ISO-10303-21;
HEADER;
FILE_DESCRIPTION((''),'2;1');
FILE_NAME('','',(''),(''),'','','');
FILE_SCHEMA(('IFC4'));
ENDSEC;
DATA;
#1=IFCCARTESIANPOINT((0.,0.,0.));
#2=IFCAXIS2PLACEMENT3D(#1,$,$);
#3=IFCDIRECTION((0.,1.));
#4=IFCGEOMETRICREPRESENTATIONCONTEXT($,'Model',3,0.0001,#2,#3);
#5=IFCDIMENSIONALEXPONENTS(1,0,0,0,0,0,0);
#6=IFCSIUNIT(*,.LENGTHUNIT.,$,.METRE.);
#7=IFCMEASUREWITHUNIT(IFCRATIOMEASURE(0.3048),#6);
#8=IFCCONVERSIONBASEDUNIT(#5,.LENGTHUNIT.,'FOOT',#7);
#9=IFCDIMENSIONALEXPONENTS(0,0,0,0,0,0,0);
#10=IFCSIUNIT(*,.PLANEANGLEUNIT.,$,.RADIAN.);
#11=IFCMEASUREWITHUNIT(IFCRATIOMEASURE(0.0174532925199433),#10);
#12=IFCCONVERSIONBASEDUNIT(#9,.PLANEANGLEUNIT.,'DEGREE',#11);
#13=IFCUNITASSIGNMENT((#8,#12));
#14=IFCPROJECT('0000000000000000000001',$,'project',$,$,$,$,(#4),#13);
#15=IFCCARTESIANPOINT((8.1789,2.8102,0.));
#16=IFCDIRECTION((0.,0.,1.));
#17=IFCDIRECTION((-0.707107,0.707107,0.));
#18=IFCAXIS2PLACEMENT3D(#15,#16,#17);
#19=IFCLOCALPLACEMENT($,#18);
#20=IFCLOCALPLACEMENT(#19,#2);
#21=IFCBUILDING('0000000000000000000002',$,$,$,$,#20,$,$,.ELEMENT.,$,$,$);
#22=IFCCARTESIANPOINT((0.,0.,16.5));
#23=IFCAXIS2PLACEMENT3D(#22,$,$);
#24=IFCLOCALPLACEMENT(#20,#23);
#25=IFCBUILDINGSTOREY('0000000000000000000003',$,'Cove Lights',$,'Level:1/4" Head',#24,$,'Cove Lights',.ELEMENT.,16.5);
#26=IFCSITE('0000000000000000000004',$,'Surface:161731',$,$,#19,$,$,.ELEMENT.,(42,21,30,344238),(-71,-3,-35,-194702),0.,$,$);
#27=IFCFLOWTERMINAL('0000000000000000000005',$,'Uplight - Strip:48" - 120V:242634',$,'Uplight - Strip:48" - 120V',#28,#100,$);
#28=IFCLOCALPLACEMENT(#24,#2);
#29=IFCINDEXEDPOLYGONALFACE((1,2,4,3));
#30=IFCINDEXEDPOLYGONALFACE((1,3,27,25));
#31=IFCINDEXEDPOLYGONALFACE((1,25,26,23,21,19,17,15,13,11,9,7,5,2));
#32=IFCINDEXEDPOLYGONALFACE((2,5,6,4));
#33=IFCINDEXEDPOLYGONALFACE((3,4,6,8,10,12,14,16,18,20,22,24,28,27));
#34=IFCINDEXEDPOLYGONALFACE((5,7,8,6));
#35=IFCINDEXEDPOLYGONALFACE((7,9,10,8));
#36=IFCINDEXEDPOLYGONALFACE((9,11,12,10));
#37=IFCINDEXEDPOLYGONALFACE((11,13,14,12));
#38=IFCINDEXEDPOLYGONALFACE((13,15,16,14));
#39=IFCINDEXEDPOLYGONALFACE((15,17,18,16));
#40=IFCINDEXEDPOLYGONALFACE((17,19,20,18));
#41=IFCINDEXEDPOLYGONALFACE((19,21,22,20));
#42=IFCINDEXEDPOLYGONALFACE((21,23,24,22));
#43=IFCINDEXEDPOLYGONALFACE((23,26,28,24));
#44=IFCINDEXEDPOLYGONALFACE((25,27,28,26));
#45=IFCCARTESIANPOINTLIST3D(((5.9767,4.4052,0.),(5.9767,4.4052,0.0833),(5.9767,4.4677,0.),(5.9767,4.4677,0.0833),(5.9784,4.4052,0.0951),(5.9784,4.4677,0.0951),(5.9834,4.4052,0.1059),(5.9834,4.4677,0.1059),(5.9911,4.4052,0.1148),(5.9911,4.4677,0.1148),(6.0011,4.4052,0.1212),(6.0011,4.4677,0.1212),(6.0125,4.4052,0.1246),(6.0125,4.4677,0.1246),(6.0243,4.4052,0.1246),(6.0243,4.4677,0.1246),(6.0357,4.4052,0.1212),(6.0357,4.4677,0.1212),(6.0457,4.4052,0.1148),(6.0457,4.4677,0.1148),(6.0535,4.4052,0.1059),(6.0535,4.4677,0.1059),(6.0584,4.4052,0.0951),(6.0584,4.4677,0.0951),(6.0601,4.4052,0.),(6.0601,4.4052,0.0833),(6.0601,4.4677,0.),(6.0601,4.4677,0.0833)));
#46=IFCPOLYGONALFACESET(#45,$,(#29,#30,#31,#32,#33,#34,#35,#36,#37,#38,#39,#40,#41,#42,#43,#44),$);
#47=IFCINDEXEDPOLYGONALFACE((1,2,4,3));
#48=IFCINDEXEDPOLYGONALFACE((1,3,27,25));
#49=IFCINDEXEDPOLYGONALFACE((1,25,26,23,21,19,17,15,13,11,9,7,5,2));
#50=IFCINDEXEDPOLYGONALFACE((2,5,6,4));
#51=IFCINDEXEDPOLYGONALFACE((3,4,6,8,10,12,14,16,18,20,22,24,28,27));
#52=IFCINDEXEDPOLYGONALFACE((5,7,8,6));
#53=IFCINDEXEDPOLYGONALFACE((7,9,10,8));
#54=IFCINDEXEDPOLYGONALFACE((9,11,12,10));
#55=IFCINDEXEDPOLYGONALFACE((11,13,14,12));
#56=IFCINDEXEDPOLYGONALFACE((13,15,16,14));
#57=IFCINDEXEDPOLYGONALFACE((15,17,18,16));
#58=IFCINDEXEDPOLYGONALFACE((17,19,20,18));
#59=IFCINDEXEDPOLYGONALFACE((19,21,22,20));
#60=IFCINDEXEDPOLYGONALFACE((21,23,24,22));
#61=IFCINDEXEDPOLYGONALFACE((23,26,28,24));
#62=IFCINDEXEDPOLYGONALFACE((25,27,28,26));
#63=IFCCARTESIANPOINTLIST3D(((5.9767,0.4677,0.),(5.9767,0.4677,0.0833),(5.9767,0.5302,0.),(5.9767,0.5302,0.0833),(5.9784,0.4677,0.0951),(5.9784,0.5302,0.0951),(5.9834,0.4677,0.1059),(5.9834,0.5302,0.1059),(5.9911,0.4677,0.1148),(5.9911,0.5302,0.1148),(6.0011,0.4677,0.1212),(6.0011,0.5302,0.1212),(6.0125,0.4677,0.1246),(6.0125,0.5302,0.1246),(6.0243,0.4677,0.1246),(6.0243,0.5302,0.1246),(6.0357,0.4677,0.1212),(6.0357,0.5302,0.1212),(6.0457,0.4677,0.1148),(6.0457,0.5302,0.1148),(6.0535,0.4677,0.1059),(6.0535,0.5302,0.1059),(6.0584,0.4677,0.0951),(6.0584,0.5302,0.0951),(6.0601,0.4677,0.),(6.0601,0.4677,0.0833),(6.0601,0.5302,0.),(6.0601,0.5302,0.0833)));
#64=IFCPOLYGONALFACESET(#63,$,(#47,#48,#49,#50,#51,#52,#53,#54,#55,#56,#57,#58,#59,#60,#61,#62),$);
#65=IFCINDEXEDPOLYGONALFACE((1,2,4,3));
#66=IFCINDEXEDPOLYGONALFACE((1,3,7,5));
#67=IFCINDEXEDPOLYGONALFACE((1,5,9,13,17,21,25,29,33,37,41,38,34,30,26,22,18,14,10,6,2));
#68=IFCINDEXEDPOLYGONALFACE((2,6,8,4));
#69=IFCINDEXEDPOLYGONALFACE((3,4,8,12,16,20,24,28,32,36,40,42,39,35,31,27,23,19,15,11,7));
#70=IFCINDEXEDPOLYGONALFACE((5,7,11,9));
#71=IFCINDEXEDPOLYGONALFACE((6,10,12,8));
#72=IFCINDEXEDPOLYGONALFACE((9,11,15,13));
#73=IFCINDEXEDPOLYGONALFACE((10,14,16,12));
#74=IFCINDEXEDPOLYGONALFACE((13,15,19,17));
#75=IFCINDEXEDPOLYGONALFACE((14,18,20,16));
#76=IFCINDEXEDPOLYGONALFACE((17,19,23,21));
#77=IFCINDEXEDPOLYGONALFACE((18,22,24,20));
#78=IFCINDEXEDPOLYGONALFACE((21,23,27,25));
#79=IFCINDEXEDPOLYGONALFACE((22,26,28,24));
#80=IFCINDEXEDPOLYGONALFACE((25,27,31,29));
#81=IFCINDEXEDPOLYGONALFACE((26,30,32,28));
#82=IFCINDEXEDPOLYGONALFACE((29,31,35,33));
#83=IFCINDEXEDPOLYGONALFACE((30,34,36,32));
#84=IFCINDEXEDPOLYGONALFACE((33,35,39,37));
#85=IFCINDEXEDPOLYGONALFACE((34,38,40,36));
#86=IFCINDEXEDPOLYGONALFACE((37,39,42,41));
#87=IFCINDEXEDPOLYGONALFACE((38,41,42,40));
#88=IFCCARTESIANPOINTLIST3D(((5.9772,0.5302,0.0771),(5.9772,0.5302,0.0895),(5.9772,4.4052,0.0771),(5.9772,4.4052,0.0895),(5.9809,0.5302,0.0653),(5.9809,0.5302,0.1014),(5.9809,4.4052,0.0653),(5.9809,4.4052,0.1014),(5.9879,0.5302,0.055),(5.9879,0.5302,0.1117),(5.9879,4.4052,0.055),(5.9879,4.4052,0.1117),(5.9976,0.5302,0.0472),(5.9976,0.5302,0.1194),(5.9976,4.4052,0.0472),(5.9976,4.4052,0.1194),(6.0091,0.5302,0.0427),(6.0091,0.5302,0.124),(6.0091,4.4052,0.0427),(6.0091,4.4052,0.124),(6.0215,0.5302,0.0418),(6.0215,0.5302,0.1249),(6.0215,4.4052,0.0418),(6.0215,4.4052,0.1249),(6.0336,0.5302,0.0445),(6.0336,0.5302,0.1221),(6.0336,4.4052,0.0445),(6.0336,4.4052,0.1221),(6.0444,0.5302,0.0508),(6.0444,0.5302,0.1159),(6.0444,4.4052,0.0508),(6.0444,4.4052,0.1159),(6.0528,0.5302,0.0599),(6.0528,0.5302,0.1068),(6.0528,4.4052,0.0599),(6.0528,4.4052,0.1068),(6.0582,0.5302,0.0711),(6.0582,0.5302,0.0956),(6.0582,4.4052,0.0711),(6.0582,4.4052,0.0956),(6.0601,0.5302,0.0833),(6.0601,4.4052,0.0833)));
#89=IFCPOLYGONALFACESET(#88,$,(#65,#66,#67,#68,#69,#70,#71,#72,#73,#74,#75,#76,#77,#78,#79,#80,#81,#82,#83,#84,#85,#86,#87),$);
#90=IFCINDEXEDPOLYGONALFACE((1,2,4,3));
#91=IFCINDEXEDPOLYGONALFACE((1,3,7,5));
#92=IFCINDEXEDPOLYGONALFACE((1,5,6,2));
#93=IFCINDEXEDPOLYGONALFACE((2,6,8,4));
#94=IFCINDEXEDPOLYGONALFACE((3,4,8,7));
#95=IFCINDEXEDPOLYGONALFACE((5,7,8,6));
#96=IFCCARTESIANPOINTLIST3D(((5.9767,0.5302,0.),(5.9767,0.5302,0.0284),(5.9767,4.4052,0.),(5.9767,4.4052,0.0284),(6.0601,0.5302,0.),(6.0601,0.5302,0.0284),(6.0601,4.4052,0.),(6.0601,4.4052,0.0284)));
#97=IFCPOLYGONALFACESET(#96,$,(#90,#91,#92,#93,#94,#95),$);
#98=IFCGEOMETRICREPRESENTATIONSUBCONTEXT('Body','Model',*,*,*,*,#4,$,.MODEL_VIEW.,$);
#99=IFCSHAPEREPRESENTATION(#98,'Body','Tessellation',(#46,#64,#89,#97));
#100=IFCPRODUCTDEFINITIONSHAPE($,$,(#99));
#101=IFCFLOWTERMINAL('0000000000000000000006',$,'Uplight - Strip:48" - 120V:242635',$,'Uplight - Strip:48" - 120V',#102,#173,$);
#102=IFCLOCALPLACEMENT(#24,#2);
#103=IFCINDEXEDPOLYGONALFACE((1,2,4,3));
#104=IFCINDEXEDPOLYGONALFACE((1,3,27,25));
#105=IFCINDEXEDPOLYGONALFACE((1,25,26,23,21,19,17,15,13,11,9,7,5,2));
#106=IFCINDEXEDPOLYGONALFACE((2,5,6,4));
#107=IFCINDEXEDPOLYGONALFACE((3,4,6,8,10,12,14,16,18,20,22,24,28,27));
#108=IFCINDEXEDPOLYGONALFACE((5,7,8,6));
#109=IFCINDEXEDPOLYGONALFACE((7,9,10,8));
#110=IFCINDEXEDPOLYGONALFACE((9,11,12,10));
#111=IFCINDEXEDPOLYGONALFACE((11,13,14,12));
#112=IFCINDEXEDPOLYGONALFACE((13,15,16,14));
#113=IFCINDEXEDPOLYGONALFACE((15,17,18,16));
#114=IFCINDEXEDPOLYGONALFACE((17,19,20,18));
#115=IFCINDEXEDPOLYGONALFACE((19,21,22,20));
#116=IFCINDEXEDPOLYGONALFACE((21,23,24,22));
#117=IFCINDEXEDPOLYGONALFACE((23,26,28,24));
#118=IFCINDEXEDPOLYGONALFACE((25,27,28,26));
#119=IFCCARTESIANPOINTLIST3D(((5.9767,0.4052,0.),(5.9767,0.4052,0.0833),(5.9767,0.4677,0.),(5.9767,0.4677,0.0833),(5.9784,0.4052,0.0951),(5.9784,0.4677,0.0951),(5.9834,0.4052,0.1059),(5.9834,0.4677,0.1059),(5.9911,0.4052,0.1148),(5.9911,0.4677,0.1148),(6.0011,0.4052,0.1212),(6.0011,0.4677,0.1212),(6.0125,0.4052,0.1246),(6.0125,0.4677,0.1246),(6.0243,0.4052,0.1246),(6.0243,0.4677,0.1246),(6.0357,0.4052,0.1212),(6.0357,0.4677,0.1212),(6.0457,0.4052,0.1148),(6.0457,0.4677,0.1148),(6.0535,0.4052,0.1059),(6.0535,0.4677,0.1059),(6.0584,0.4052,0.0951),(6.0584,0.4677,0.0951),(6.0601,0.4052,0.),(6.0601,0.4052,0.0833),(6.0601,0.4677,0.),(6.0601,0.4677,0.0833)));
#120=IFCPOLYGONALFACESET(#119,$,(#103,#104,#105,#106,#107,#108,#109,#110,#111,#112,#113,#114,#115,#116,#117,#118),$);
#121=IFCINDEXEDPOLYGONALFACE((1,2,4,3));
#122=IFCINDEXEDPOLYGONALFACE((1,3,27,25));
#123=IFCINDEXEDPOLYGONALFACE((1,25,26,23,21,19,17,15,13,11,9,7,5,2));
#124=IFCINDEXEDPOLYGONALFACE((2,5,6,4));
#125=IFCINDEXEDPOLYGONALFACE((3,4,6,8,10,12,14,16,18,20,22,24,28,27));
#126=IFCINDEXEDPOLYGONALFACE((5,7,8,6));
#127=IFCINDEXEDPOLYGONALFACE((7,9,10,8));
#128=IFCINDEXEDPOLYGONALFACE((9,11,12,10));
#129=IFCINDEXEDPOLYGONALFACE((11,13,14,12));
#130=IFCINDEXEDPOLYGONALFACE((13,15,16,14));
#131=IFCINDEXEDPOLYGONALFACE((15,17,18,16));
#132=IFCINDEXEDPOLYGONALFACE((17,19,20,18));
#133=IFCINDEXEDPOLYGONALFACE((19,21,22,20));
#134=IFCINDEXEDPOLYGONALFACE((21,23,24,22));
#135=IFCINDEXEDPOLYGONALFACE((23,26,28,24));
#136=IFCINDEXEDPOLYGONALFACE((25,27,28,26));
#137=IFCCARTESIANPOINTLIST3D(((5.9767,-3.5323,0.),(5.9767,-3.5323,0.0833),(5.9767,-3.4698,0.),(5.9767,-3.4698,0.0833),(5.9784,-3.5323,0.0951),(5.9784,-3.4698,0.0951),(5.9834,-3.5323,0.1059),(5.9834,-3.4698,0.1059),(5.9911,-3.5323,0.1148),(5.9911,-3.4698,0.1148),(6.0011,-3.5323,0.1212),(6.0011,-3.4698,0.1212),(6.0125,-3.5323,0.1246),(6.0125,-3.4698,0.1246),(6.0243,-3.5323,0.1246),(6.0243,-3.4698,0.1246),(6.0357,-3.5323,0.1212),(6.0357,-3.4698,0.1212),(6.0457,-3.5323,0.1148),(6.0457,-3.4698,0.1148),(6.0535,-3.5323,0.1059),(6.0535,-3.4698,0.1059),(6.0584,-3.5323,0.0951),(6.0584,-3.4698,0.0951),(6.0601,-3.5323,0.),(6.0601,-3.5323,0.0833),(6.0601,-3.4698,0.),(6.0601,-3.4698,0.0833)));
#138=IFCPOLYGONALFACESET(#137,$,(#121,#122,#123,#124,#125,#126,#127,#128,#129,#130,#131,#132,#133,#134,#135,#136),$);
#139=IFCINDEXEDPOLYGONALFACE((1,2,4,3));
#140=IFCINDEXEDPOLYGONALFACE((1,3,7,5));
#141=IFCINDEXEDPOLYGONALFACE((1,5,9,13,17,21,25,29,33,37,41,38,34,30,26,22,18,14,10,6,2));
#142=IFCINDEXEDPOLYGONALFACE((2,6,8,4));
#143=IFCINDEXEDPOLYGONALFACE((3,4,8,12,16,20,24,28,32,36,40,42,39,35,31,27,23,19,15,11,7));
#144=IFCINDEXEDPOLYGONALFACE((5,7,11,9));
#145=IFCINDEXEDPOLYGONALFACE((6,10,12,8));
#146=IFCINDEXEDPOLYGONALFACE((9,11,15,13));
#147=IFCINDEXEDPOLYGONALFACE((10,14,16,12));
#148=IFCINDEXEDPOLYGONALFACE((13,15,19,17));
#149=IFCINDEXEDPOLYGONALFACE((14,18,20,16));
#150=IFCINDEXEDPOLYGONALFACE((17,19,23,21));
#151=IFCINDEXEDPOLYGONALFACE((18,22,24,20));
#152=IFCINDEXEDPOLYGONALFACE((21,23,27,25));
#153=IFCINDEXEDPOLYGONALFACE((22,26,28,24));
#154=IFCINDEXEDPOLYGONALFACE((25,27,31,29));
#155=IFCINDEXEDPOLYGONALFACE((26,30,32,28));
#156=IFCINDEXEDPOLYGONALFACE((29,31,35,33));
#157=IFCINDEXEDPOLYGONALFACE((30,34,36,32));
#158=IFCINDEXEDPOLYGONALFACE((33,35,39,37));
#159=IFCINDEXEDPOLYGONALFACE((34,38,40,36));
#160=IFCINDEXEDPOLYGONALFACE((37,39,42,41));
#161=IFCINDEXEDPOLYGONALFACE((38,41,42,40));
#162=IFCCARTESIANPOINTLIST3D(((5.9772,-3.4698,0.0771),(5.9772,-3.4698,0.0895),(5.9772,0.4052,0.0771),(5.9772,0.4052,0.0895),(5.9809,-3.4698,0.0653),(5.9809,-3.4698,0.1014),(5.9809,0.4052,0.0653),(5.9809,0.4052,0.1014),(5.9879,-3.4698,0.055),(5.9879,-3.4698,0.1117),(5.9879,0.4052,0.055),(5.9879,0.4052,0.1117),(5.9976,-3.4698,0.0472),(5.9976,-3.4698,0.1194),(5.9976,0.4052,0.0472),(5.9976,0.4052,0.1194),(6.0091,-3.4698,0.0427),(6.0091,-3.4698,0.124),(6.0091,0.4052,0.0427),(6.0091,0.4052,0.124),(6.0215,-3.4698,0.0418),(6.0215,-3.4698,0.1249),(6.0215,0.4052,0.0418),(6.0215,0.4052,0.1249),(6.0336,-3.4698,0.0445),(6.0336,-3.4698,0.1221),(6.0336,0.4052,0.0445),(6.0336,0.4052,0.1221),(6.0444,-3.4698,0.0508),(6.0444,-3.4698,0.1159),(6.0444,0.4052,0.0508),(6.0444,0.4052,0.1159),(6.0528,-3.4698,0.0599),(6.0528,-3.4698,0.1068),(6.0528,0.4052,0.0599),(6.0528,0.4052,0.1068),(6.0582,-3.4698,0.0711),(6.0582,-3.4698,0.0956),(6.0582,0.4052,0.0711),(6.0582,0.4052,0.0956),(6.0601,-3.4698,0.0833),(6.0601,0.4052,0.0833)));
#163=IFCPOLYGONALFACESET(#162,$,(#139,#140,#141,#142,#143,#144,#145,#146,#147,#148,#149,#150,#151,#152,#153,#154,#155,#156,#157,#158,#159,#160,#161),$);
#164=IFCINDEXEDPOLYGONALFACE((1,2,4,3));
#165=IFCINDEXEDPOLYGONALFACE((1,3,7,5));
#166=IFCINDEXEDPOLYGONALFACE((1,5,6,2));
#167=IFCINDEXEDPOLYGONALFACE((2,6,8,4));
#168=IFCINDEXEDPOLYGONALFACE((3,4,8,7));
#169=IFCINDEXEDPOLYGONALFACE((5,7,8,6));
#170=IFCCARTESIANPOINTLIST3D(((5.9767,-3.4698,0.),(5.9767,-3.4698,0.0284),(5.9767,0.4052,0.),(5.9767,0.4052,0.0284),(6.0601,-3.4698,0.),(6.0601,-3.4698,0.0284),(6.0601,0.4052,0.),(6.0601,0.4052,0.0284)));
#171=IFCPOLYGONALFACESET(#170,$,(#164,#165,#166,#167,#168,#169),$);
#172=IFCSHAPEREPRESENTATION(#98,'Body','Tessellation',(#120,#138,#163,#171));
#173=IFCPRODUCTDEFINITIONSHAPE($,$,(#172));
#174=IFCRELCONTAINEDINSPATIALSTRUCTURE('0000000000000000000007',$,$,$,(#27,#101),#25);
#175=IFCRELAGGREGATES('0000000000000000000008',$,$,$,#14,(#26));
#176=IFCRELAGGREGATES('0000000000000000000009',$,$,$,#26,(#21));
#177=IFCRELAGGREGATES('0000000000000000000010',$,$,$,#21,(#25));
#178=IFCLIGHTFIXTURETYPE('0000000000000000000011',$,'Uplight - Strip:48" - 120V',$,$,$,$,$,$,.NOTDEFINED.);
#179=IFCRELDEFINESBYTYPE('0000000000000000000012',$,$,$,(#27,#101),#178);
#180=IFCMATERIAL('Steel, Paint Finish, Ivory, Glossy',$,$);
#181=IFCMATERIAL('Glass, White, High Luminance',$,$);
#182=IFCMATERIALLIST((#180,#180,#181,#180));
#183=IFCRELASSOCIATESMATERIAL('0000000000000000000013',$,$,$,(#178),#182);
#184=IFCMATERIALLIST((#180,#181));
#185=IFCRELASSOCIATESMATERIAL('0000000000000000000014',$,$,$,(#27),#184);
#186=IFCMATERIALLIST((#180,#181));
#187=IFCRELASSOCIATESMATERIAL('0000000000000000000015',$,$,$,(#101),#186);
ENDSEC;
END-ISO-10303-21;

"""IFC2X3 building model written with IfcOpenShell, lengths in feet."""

from ifc_helpers import new_model, entity, si_unit, converted_unit, direction, frame, frame_2d, origin, origin_2d_with_axis, place, context, subcontext, project, spatial, polyline, circle_curve, parameter, trimmed, segment, composite_curve, rectangle, circle, outline, extrude, source, transform, mapped, material, material_list, type_object, type_shapes, element, save


model = new_model("IFC2X3")

# Units and contexts
model_context = context("Model", 3, precision=0.0001, world=origin(), true_north=direction((0.0, 1.0)))
body_context = subcontext(model_context, "Body", "Model", "MODEL_VIEW")
ifc_project = project(units=[converted_unit("LENGTHUNIT", "FOOT", entity("IfcRatioMeasure", 0.3048), si_unit("LENGTHUNIT", "METRE"), dimensions=[1, 0, 0, 0, 0, 0, 0]), converted_unit("PLANEANGLEUNIT", "DEGREE", entity("IfcRatioMeasure", 0.0174532925199433), si_unit("PLANEANGLEUNIT", "RADIAN"), dimensions=[0, 0, 0, 0, 0, 0, 0])], contexts=[model_context])

# Site, building, storey
site_placement = place(None, frame((8.1789, 2.8102, 0.0), z_axis=(0.0, 0.0, 1.0), x_axis=(-0.707107, 0.707107, 0.0)))
site = spatial("IfcSite", under=ifc_project, at=site_placement, Name="Surface:161731", CompositionType="ELEMENT", RefLatitude=(42, 21, 30, 344238), RefLongitude=(-71, -3, -35, -194702), RefElevation=0.0)
building_placement = place(site_placement, origin())
building = spatial("IfcBuilding", under=site, at=building_placement, CompositionType="ELEMENT")
storey_placement = place(building_placement, frame((0.0, 0.0, 16.5)))
storey = spatial("IfcBuildingStorey", under=building, at=storey_placement, Name="Cove Lights", ObjectType="Level:1/4\" Head", LongName="Cove Lights", CompositionType="ELEMENT", Elevation=16.5)

# Flow terminals
ifc_material_1 = material(Name="Steel, Paint Finish, Ivory, Glossy")
ifc_material_2 = material(Name="Glass, White, High Luminance")
ifc_material_list_1 = material_list([ifc_material_1, ifc_material_1, ifc_material_2, ifc_material_1])
light_fixture_type_1 = type_object("IfcLightFixtureType", Name="Uplight - Strip:48\" - 120V", PredefinedType="NOTDEFINED", material=ifc_material_list_1)
shared_shape_1 = source(origin(), body_context, "Body", "SweptSolid", [
    extrude(outline(composite_curve([segment(polyline([(-0.0417, -0.0417), (0.0417, -0.0417)]), True, "CONTINUOUS"), segment(polyline([(0.0417, -0.0417), (0.0417, 0.0417)]), True, "CONTINUOUS"), segment(trimmed(circle_curve(frame_2d((0.0, 0.0417), x_axis=(-1.0, 0.0)), 0.0417), [parameter(180.0)], [parameter(0.0)], True, "PARAMETER"), True, "CONTINUOUS"), segment(polyline([(-0.0417, 0.0417), (-0.0417, -0.0417)]), True, "CONTINUOUS")], self_intersect=False)), frame((1.9375, 0.0, 0.0417), z_axis=(1.0, 0.0, 0.0), x_axis=(0.0, 1.0, 0.0)), (0.0, 0.0, 1.0), 0.0625),
    extrude(outline(composite_curve([segment(polyline([(-0.0417, -0.0417), (0.0417, -0.0417)]), True, "CONTINUOUS"), segment(trimmed(circle_curve(frame_2d((0.0417, 0.0), x_axis=(1.0, 0.0)), 0.0417), [parameter(270.0)], [parameter(90.0)], True, "PARAMETER"), True, "CONTINUOUS"), segment(polyline([(0.0417, 0.0417), (-0.0417, 0.0417)]), True, "CONTINUOUS"), segment(polyline([(-0.0417, 0.0417), (-0.0417, -0.0417)]), True, "CONTINUOUS")], self_intersect=False)), frame((-2.0, 0.0, 0.0417), z_axis=(1.0, 0.0, 0.0), x_axis=(0.0, 0.0, 1.0)), (0.0, 0.0, 1.0), 0.0625),
    extrude(circle(Radius=0.0417, at=frame_2d((0.0, 0.0), x_axis=(1.0, 0.0))), frame((-1.9375, 0.0, 0.0833), z_axis=(1.0, 0.0, 0.0), x_axis=(0.0, -1.0, 0.0)), (0.0, 0.0, 1.0), 3.875),
    extrude(rectangle(XDim=0.0833, YDim=3.875, at=origin_2d_with_axis()), frame((0.0, 0.0, 0.0), z_axis=(0.0, 0.0, 1.0), x_axis=(0.0, 1.0, 0.0)), (0.0, 0.0, 1.0), 0.0284),
])
type_shapes(light_fixture_type_1, [shared_shape_1])
ifc_material_list_2 = material_list([ifc_material_1, ifc_material_2])
flow_terminal_1_placement = place(storey_placement, frame((6.0184, 2.4677, 0.0), z_axis=(0.0, 0.0, 1.0), x_axis=(0.0, 1.0, 0.0)))
element("IfcFlowTerminal", 1, at=flow_terminal_1_placement, inside=storey, type_object=light_fixture_type_1, material=ifc_material_list_2, Name="Uplight - Strip:48\" - 120V:242634", ObjectType="Uplight - Strip:48\" - 120V", context=body_context, shape_type="MappedRepresentation", body=[
    mapped(shared_shape_1, transform((0.0, 0.0, 0.0), scale=1.0)),
])
ifc_material_list_3 = material_list([ifc_material_1, ifc_material_2])
flow_terminal_2_placement = place(storey_placement, frame((6.0184, -1.5323, 0.0), z_axis=(0.0, 0.0, 1.0), x_axis=(0.0, 1.0, 0.0)))
element("IfcFlowTerminal", 2, at=flow_terminal_2_placement, inside=storey, type_object=light_fixture_type_1, material=ifc_material_list_3, Name="Uplight - Strip:48\" - 120V:242635", ObjectType="Uplight - Strip:48\" - 120V", context=body_context, shape_type="MappedRepresentation", body=[
    mapped(shared_shape_1, transform((0.0, 0.0, 0.0), scale=1.0)),
])

save(model, "model.ifc")
